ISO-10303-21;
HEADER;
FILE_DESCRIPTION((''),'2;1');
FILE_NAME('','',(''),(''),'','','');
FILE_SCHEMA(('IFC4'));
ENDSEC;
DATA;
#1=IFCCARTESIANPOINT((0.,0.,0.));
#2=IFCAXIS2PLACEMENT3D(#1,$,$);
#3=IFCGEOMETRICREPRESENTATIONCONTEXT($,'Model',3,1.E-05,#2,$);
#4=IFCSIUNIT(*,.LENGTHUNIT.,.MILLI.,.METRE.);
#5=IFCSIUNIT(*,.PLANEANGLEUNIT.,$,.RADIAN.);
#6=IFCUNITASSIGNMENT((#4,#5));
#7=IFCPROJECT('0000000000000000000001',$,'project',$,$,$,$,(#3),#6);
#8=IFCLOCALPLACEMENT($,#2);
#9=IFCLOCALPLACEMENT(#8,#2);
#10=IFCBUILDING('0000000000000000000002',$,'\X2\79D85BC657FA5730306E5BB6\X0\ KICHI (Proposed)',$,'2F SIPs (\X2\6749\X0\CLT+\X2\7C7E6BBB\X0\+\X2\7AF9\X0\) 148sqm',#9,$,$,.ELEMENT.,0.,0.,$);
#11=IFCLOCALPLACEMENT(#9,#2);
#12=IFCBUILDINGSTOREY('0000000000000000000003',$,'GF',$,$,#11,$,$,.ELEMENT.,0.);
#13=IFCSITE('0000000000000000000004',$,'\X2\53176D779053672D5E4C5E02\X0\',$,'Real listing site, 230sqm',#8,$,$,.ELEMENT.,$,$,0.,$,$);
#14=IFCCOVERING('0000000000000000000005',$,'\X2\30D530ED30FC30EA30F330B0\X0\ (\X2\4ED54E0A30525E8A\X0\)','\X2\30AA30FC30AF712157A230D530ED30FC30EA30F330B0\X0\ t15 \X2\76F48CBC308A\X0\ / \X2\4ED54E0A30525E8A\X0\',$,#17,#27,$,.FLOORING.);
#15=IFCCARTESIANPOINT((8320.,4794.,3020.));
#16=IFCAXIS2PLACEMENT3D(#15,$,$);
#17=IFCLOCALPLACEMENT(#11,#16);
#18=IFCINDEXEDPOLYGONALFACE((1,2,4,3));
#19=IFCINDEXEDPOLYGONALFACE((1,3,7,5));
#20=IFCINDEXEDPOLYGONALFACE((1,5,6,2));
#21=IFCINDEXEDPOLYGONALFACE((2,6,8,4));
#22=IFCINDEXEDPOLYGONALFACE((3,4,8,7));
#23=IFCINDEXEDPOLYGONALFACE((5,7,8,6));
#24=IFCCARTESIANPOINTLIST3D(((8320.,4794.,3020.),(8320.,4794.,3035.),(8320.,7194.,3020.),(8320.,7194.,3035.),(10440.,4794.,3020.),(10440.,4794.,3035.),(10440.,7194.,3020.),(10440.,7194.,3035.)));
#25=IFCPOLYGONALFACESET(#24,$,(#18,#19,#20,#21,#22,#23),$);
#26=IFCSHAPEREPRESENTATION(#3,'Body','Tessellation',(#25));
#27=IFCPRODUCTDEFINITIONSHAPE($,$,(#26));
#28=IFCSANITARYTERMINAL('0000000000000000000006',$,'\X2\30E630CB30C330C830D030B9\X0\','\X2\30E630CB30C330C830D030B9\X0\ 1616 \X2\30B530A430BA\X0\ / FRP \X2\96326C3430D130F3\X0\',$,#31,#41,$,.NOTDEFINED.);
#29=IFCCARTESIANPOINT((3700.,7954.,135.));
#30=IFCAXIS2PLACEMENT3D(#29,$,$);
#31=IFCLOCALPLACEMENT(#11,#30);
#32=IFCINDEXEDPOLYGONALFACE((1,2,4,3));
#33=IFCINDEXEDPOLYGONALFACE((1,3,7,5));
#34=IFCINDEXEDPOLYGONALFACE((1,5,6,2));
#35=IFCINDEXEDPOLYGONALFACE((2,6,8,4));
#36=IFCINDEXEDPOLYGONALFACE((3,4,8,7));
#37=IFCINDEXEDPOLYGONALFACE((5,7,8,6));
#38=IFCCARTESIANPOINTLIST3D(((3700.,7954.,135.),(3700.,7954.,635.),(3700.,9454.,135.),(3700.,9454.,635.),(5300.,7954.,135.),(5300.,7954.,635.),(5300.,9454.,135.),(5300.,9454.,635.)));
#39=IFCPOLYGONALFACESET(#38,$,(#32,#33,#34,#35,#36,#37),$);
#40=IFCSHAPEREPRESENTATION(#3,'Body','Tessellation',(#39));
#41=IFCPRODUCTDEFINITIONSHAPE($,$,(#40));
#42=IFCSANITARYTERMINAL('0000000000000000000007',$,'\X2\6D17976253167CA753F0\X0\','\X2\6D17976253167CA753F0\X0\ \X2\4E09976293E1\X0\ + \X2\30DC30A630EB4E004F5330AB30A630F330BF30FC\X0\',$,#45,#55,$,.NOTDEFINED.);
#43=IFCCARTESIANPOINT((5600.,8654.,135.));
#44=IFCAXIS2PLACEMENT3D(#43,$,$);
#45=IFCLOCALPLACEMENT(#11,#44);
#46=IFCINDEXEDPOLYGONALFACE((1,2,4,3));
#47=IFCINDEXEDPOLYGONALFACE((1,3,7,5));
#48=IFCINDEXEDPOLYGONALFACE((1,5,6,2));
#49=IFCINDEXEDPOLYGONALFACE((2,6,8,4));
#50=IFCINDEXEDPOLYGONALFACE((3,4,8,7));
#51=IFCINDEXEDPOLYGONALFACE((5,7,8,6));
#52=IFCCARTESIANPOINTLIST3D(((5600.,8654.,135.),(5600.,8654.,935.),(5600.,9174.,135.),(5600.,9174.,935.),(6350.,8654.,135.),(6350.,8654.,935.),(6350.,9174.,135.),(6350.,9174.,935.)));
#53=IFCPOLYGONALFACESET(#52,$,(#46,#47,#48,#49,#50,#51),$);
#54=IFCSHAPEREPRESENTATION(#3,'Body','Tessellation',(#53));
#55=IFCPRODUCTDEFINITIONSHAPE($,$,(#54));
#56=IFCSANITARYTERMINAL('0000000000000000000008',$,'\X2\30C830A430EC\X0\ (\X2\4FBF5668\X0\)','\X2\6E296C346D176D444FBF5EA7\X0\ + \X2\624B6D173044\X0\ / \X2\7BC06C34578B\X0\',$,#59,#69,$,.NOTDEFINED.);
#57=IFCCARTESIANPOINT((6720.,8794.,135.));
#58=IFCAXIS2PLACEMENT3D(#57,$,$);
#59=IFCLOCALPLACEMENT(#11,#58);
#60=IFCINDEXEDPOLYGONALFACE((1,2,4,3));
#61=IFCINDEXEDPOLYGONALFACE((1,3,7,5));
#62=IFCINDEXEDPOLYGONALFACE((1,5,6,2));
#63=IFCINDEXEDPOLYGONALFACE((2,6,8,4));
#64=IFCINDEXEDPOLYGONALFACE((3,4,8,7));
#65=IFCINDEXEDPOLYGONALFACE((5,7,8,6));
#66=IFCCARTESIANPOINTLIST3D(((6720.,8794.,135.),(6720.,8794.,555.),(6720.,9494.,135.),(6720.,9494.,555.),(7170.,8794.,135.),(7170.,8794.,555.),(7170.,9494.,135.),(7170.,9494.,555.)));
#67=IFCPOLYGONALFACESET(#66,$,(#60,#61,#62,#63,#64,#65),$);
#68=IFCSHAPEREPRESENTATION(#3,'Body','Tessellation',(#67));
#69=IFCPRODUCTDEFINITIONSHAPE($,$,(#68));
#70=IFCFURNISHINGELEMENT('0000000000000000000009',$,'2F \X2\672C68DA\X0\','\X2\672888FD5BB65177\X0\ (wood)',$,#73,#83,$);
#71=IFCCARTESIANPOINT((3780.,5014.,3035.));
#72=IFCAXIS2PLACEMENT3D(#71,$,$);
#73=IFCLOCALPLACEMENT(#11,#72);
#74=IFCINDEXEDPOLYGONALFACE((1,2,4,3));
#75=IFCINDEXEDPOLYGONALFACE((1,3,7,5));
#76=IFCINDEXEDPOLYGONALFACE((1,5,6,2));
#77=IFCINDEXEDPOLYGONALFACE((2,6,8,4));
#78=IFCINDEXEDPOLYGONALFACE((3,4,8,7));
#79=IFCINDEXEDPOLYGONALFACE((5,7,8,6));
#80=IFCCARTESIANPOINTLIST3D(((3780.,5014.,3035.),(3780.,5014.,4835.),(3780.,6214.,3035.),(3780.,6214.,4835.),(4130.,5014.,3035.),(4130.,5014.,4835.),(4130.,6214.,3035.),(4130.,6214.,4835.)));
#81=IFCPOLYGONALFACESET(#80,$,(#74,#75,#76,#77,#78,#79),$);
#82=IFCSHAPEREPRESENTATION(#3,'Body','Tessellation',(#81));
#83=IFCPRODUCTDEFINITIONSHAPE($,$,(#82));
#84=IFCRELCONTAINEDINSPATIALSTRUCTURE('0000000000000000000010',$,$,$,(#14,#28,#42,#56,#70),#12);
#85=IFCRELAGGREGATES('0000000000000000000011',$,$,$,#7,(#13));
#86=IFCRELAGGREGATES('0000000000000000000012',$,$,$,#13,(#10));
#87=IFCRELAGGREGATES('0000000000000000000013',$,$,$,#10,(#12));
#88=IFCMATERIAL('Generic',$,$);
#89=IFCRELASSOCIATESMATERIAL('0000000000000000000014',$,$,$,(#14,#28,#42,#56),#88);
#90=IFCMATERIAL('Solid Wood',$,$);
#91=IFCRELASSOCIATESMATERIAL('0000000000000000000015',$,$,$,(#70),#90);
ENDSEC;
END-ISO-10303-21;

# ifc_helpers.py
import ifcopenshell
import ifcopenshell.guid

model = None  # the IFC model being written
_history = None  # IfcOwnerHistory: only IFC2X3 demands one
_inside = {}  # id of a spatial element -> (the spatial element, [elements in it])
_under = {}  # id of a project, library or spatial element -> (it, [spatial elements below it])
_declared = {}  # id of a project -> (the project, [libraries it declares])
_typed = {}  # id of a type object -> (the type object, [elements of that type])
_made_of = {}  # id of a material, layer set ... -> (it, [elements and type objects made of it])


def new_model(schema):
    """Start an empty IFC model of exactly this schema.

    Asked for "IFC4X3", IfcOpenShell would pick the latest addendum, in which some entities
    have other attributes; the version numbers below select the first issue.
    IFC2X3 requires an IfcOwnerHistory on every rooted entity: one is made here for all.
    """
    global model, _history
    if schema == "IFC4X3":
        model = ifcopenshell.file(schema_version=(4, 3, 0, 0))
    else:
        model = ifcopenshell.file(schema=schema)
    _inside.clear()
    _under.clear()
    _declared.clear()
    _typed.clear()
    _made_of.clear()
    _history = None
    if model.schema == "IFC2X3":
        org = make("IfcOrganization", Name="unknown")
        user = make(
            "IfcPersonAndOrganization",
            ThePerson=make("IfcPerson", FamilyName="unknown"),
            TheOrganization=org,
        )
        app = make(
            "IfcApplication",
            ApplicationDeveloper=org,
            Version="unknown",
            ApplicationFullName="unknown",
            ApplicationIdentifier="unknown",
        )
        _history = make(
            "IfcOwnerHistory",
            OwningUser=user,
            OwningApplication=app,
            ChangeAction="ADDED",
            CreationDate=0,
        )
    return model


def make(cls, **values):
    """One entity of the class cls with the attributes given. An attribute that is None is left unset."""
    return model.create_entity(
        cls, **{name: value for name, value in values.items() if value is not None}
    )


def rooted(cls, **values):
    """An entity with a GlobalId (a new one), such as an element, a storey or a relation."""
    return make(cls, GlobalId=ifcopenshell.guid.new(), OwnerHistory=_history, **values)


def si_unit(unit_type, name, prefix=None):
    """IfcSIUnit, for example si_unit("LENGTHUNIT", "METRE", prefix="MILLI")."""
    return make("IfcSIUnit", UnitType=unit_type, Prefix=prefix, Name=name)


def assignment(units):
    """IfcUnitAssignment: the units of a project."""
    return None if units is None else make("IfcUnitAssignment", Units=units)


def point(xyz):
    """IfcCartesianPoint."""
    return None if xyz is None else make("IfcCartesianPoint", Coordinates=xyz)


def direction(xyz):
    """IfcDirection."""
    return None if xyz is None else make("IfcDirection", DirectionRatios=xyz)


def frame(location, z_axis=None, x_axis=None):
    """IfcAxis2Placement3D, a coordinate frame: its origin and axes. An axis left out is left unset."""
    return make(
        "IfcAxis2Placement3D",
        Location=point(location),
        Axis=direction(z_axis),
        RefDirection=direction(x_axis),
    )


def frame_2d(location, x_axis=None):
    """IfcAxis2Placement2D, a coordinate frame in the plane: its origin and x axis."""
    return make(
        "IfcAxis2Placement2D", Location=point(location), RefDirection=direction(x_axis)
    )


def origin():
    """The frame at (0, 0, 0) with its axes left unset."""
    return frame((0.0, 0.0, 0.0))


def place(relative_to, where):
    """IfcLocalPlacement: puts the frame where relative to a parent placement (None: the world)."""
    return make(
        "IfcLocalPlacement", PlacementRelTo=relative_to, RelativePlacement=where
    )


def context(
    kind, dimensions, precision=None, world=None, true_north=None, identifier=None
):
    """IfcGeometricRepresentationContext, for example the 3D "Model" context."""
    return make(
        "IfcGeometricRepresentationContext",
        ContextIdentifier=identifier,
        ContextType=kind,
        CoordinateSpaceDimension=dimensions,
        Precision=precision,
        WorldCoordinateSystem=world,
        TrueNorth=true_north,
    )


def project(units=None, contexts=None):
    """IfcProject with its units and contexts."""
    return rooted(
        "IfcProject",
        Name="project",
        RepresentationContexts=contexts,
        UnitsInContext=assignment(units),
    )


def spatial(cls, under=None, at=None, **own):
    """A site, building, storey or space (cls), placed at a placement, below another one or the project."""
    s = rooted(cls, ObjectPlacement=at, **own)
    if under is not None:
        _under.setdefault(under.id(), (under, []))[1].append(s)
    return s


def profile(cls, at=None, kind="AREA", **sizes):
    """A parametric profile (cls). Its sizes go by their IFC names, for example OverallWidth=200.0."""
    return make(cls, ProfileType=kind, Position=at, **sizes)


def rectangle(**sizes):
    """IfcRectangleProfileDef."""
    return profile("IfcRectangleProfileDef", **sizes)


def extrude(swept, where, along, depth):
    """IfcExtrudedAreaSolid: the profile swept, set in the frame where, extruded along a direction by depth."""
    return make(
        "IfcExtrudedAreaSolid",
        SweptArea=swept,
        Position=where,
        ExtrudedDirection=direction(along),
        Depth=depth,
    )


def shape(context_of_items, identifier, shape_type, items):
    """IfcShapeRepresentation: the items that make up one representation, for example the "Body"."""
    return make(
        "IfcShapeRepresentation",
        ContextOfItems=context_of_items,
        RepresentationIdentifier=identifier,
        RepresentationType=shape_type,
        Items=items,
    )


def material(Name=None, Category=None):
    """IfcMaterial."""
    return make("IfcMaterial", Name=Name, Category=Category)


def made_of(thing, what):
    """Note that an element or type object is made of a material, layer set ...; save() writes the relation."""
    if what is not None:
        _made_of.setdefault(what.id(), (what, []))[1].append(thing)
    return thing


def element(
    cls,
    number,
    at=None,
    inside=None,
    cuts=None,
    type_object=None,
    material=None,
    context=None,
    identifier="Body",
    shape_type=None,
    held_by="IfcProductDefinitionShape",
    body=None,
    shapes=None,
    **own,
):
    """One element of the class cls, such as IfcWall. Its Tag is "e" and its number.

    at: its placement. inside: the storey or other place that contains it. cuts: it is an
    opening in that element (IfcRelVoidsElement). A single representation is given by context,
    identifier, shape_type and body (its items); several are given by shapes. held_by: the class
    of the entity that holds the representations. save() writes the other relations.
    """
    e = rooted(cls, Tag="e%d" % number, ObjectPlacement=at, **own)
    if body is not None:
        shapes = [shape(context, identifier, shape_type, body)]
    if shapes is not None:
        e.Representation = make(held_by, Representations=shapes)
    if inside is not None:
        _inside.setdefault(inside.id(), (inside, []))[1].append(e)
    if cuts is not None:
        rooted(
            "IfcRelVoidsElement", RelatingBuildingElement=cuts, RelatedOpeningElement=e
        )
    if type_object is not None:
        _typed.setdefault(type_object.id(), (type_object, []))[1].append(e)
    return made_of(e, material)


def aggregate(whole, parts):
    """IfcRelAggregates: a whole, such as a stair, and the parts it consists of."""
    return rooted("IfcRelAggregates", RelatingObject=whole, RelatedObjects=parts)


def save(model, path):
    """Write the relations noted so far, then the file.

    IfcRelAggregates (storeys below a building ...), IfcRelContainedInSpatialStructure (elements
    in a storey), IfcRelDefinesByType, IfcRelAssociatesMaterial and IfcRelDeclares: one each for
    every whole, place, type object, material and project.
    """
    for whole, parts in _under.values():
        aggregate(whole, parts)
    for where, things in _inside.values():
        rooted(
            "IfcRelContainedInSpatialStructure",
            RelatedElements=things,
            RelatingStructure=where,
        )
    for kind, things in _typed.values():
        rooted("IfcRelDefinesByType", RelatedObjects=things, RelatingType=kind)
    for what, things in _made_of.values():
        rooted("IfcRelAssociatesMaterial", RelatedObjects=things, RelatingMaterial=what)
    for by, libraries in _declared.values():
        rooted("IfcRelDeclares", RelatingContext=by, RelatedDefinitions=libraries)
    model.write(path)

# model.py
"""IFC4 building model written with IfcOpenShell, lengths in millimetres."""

from ifc_helpers import new_model, si_unit, frame, frame_2d, origin, place, context, project, spatial, rectangle, extrude, material, element, save


model = new_model("IFC4")

# Units and contexts
model_context = context("Model", 3, precision=1e-05, world=origin())
ifc_project = project(units=[si_unit("LENGTHUNIT", "METRE", prefix="MILLI"), si_unit("PLANEANGLEUNIT", "RADIAN")], contexts=[model_context])

# Site, building, storey
site_placement = place(None, origin())
site = spatial("IfcSite", under=ifc_project, at=site_placement, Name="北海道札幌市", ObjectType="Real listing site, 230sqm", CompositionType="ELEMENT", RefElevation=0.0)
building_placement = place(site_placement, origin())
building = spatial("IfcBuilding", under=site, at=building_placement, Name="秘密基地の家 KICHI (Proposed)", ObjectType="2F SIPs (杉CLT+籾殻+竹) 148sqm", CompositionType="ELEMENT", ElevationOfRefHeight=0.0, ElevationOfTerrain=0.0)
storey_placement = place(building_placement, origin())
storey = spatial("IfcBuildingStorey", under=building, at=storey_placement, Name="GF", CompositionType="ELEMENT", Elevation=0.0)

# Shared definitions
ifc_material_1 = material(Name="Solid Wood")
ifc_material_2 = material(Name="Generic")

# Covering
covering_1_placement = place(storey_placement, frame((8320.0, 4794.0, 3020.0)))
element("IfcCovering", 1, at=covering_1_placement, inside=storey, material=ifc_material_2, Name="フローリング (仕上げ床)", Description="オーク無垢フローリング t15 直貼り / 仕上げ床", PredefinedType="FLOORING", context=model_context, shape_type="SweptSolid", body=[
    extrude(rectangle(XDim=2120.0, YDim=2400.0, at=frame_2d((1060.0, 1200.0))), frame((8320.0, 4794.0, 3020.0)), (0.0, 0.0, 1.0), 15.0),
])

# Sanitary terminals
sanitary_terminal_1_placement = place(storey_placement, frame((3700.0, 7954.0, 135.0)))
element("IfcSanitaryTerminal", 2, at=sanitary_terminal_1_placement, inside=storey, material=ifc_material_2, Name="ユニットバス", Description="ユニットバス 1616 サイズ / FRP 防水パン", PredefinedType="NOTDEFINED", context=model_context, shape_type="SweptSolid", body=[
    extrude(rectangle(XDim=1600.0, YDim=1500.0, at=frame_2d((800.0, 750.0))), frame((3700.0, 7954.0, 135.0)), (0.0, 0.0, 1.0), 500.0),
])
sanitary_terminal_2_placement = place(storey_placement, frame((5600.0, 8654.0, 135.0)))
element("IfcSanitaryTerminal", 3, at=sanitary_terminal_2_placement, inside=storey, material=ifc_material_2, Name="洗面化粧台", Description="洗面化粧台 三面鏡 + ボウル一体カウンター", PredefinedType="NOTDEFINED", context=model_context, shape_type="SweptSolid", body=[
    extrude(rectangle(XDim=750.0, YDim=520.0, at=frame_2d((375.0, 260.0))), frame((5600.0, 8654.0, 135.0)), (0.0, 0.0, 1.0), 800.0),
])
sanitary_terminal_3_placement = place(storey_placement, frame((6720.0, 8794.0, 135.0)))
element("IfcSanitaryTerminal", 4, at=sanitary_terminal_3_placement, inside=storey, material=ifc_material_2, Name="トイレ (便器)", Description="温水洗浄便座 + 手洗い / 節水型", PredefinedType="NOTDEFINED", context=model_context, shape_type="SweptSolid", body=[
    extrude(rectangle(XDim=450.0, YDim=700.0, at=frame_2d((225.0, 350.0))), frame((6720.0, 8794.0, 135.0)), (0.0, 0.0, 1.0), 420.0),
])

# Furnishing element
furnishing_placement = place(storey_placement, frame((3780.0, 5014.0, 3035.0)))
element("IfcFurnishingElement", 5, at=furnishing_placement, inside=storey, material=ifc_material_1, Name="2F 本棚", Description="木製家具 (wood)", context=model_context, shape_type="SweptSolid", body=[
    extrude(rectangle(XDim=350.0, YDim=1200.0, at=frame_2d((175.0, 600.0))), frame((3780.0, 5014.0, 3035.0)), (0.0, 0.0, 1.0), 1800.0),
])

save(model, "model.ifc")
